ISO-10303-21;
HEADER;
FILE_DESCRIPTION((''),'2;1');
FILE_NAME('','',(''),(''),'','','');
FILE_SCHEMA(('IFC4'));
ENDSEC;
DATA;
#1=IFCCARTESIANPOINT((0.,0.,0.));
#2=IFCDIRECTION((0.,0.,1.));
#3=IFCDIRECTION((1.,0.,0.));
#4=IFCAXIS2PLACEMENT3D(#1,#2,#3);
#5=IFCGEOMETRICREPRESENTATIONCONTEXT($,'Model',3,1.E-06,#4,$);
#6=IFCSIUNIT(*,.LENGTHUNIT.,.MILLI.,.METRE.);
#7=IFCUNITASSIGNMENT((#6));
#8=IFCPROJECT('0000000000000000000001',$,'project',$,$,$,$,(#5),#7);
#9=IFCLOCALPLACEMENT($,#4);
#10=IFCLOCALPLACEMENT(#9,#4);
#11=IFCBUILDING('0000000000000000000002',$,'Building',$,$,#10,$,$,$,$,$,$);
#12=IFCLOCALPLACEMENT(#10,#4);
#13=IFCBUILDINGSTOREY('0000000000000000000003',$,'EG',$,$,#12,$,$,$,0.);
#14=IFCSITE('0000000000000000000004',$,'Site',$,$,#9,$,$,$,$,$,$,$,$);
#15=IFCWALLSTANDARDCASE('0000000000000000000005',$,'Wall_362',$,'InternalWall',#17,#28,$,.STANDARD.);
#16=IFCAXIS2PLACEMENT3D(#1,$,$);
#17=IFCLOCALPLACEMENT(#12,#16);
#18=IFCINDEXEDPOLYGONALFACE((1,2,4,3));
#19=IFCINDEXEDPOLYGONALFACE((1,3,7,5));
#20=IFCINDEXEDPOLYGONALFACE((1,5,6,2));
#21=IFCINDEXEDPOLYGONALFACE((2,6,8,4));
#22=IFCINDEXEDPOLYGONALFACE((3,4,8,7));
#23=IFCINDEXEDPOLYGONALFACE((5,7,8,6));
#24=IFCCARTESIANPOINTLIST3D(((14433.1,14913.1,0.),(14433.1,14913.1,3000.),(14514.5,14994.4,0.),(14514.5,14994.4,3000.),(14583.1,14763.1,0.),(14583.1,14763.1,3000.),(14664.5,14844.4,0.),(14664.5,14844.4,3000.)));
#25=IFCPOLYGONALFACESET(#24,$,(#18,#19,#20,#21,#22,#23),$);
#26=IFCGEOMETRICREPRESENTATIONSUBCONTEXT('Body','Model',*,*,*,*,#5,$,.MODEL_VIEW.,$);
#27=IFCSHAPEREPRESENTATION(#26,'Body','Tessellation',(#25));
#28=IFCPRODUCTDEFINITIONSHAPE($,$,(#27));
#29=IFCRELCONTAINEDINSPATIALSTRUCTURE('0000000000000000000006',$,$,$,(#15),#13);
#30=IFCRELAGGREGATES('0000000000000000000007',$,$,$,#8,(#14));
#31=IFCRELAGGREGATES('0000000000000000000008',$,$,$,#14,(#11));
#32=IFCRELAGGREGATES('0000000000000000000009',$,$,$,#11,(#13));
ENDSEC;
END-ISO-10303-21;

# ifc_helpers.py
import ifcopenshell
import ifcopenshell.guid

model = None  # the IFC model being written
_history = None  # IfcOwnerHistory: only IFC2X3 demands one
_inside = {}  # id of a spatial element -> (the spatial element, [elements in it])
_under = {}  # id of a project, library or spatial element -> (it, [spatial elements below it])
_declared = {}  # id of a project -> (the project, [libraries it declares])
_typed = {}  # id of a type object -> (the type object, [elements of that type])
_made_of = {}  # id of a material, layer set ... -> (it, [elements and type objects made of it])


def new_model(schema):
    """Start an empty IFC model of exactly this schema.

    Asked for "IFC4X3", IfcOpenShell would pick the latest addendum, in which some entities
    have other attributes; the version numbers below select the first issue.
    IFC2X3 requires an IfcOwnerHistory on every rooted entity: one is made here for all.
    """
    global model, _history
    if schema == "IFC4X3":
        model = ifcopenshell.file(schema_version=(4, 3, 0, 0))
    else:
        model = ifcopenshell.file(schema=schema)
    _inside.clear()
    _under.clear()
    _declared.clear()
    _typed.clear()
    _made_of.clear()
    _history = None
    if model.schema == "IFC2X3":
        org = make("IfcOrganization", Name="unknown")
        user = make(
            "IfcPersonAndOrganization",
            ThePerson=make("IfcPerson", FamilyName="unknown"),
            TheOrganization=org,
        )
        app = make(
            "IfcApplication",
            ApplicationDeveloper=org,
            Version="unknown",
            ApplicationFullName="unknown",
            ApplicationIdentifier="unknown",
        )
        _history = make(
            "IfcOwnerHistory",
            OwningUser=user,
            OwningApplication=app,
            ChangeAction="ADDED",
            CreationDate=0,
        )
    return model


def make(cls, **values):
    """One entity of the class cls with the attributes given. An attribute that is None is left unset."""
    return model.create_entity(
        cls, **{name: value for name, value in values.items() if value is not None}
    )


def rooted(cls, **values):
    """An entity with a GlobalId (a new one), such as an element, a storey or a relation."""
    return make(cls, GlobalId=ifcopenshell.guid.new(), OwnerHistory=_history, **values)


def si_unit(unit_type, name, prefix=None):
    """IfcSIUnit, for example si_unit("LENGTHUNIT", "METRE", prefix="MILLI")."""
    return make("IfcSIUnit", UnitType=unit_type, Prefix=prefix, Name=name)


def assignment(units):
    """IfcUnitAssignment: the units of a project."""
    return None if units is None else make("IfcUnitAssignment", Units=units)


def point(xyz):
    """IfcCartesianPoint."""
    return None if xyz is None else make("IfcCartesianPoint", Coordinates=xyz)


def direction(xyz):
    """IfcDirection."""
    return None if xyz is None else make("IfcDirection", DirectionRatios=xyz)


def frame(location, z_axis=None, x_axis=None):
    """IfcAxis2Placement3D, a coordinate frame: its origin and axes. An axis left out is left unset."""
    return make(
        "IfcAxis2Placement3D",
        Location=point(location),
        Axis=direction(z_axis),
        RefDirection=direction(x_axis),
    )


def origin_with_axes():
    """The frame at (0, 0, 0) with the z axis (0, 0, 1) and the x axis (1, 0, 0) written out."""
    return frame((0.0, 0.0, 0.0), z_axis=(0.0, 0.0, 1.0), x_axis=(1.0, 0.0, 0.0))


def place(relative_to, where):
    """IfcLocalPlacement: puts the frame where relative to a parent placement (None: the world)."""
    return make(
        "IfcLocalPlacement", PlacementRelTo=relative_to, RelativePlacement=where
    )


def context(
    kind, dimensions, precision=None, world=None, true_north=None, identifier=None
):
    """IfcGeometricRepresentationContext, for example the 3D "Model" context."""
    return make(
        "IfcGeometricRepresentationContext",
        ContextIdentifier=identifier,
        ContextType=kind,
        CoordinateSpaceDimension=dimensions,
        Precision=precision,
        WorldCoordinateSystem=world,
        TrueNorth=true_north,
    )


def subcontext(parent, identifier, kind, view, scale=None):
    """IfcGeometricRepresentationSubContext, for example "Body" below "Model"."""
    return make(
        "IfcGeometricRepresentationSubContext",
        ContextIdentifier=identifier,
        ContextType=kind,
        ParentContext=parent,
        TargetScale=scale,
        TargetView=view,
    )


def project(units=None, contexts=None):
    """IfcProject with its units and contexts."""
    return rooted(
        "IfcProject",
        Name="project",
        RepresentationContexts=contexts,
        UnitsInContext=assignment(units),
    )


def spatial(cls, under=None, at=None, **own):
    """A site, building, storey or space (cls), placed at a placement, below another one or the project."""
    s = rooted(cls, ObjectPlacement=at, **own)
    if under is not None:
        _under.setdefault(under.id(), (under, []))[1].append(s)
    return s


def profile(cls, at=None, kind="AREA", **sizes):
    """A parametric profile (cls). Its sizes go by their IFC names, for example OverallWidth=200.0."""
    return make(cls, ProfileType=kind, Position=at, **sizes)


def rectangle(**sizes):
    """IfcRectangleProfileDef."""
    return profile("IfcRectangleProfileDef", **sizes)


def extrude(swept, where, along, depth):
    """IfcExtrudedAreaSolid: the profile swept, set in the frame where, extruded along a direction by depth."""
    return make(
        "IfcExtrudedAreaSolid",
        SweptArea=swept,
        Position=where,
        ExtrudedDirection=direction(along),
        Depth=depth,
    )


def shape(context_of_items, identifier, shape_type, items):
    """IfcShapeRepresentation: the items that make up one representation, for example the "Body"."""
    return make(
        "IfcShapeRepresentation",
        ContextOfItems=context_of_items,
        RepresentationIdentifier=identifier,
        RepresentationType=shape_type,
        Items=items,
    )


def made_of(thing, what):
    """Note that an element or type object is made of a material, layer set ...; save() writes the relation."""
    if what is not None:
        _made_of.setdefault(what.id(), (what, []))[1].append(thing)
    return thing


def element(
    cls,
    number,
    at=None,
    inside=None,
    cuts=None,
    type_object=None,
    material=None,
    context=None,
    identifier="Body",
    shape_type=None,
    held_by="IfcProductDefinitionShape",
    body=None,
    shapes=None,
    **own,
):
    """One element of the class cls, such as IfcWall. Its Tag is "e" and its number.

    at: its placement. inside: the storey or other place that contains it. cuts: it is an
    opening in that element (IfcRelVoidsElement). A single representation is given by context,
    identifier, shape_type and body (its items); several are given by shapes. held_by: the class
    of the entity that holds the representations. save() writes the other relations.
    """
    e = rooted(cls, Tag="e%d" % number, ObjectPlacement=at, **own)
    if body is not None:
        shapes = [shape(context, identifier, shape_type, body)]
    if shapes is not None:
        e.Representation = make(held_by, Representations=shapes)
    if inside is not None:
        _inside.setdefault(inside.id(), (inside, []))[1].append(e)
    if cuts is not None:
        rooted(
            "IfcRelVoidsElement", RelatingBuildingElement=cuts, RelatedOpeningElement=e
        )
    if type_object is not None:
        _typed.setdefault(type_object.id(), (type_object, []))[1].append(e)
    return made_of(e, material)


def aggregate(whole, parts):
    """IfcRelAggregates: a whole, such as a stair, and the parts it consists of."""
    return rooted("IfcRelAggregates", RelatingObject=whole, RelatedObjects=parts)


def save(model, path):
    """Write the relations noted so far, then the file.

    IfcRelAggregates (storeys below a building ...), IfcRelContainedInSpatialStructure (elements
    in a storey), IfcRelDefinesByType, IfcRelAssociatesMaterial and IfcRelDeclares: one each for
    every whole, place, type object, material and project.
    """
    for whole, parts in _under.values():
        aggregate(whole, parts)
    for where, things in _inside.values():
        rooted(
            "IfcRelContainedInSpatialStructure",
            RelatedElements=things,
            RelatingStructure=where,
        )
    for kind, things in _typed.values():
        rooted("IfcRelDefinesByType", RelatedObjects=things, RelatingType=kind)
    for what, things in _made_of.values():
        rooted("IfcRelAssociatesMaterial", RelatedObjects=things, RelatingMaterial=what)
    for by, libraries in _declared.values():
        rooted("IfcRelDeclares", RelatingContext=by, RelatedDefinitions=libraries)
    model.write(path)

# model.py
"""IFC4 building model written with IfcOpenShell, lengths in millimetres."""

from ifc_helpers import new_model, si_unit, frame, origin_with_axes, place, context, subcontext, project, spatial, rectangle, extrude, element, save


model = new_model("IFC4")

# Units and contexts
model_context = context("Model", 3, precision=1e-06, world=origin_with_axes())
body_context = subcontext(model_context, "Body", "Model", "MODEL_VIEW")
ifc_project = project(units=[si_unit("LENGTHUNIT", "METRE", prefix="MILLI")], contexts=[model_context])

# Site, building, storey
site_placement = place(None, origin_with_axes())
site = spatial("IfcSite", under=ifc_project, at=site_placement, Name="Site")
building_placement = place(site_placement, origin_with_axes())
building = spatial("IfcBuilding", under=site, at=building_placement, Name="Building")
storey_placement = place(building_placement, origin_with_axes())
storey = spatial("IfcBuildingStorey", under=building, at=storey_placement, Name="EG", Elevation=0.0)

# Wall
wall_1_placement = place(storey_placement, origin_with_axes())
element("IfcWallStandardCase", 1, at=wall_1_placement, inside=storey, Name="Wall_362", ObjectType="InternalWall", PredefinedType="STANDARD", context=body_context, shape_type="SweptSolid", body=[
    extrude(rectangle(XDim=212.1, YDim=115.0), frame((14548.8, 14878.7, 0.0), z_axis=(0.0, 0.0, 1.0), x_axis=(-0.707107, 0.707107, 0.0)), (0.0, 0.0, 1.0), 3000.0),
])

save(model, "model.ifc")
